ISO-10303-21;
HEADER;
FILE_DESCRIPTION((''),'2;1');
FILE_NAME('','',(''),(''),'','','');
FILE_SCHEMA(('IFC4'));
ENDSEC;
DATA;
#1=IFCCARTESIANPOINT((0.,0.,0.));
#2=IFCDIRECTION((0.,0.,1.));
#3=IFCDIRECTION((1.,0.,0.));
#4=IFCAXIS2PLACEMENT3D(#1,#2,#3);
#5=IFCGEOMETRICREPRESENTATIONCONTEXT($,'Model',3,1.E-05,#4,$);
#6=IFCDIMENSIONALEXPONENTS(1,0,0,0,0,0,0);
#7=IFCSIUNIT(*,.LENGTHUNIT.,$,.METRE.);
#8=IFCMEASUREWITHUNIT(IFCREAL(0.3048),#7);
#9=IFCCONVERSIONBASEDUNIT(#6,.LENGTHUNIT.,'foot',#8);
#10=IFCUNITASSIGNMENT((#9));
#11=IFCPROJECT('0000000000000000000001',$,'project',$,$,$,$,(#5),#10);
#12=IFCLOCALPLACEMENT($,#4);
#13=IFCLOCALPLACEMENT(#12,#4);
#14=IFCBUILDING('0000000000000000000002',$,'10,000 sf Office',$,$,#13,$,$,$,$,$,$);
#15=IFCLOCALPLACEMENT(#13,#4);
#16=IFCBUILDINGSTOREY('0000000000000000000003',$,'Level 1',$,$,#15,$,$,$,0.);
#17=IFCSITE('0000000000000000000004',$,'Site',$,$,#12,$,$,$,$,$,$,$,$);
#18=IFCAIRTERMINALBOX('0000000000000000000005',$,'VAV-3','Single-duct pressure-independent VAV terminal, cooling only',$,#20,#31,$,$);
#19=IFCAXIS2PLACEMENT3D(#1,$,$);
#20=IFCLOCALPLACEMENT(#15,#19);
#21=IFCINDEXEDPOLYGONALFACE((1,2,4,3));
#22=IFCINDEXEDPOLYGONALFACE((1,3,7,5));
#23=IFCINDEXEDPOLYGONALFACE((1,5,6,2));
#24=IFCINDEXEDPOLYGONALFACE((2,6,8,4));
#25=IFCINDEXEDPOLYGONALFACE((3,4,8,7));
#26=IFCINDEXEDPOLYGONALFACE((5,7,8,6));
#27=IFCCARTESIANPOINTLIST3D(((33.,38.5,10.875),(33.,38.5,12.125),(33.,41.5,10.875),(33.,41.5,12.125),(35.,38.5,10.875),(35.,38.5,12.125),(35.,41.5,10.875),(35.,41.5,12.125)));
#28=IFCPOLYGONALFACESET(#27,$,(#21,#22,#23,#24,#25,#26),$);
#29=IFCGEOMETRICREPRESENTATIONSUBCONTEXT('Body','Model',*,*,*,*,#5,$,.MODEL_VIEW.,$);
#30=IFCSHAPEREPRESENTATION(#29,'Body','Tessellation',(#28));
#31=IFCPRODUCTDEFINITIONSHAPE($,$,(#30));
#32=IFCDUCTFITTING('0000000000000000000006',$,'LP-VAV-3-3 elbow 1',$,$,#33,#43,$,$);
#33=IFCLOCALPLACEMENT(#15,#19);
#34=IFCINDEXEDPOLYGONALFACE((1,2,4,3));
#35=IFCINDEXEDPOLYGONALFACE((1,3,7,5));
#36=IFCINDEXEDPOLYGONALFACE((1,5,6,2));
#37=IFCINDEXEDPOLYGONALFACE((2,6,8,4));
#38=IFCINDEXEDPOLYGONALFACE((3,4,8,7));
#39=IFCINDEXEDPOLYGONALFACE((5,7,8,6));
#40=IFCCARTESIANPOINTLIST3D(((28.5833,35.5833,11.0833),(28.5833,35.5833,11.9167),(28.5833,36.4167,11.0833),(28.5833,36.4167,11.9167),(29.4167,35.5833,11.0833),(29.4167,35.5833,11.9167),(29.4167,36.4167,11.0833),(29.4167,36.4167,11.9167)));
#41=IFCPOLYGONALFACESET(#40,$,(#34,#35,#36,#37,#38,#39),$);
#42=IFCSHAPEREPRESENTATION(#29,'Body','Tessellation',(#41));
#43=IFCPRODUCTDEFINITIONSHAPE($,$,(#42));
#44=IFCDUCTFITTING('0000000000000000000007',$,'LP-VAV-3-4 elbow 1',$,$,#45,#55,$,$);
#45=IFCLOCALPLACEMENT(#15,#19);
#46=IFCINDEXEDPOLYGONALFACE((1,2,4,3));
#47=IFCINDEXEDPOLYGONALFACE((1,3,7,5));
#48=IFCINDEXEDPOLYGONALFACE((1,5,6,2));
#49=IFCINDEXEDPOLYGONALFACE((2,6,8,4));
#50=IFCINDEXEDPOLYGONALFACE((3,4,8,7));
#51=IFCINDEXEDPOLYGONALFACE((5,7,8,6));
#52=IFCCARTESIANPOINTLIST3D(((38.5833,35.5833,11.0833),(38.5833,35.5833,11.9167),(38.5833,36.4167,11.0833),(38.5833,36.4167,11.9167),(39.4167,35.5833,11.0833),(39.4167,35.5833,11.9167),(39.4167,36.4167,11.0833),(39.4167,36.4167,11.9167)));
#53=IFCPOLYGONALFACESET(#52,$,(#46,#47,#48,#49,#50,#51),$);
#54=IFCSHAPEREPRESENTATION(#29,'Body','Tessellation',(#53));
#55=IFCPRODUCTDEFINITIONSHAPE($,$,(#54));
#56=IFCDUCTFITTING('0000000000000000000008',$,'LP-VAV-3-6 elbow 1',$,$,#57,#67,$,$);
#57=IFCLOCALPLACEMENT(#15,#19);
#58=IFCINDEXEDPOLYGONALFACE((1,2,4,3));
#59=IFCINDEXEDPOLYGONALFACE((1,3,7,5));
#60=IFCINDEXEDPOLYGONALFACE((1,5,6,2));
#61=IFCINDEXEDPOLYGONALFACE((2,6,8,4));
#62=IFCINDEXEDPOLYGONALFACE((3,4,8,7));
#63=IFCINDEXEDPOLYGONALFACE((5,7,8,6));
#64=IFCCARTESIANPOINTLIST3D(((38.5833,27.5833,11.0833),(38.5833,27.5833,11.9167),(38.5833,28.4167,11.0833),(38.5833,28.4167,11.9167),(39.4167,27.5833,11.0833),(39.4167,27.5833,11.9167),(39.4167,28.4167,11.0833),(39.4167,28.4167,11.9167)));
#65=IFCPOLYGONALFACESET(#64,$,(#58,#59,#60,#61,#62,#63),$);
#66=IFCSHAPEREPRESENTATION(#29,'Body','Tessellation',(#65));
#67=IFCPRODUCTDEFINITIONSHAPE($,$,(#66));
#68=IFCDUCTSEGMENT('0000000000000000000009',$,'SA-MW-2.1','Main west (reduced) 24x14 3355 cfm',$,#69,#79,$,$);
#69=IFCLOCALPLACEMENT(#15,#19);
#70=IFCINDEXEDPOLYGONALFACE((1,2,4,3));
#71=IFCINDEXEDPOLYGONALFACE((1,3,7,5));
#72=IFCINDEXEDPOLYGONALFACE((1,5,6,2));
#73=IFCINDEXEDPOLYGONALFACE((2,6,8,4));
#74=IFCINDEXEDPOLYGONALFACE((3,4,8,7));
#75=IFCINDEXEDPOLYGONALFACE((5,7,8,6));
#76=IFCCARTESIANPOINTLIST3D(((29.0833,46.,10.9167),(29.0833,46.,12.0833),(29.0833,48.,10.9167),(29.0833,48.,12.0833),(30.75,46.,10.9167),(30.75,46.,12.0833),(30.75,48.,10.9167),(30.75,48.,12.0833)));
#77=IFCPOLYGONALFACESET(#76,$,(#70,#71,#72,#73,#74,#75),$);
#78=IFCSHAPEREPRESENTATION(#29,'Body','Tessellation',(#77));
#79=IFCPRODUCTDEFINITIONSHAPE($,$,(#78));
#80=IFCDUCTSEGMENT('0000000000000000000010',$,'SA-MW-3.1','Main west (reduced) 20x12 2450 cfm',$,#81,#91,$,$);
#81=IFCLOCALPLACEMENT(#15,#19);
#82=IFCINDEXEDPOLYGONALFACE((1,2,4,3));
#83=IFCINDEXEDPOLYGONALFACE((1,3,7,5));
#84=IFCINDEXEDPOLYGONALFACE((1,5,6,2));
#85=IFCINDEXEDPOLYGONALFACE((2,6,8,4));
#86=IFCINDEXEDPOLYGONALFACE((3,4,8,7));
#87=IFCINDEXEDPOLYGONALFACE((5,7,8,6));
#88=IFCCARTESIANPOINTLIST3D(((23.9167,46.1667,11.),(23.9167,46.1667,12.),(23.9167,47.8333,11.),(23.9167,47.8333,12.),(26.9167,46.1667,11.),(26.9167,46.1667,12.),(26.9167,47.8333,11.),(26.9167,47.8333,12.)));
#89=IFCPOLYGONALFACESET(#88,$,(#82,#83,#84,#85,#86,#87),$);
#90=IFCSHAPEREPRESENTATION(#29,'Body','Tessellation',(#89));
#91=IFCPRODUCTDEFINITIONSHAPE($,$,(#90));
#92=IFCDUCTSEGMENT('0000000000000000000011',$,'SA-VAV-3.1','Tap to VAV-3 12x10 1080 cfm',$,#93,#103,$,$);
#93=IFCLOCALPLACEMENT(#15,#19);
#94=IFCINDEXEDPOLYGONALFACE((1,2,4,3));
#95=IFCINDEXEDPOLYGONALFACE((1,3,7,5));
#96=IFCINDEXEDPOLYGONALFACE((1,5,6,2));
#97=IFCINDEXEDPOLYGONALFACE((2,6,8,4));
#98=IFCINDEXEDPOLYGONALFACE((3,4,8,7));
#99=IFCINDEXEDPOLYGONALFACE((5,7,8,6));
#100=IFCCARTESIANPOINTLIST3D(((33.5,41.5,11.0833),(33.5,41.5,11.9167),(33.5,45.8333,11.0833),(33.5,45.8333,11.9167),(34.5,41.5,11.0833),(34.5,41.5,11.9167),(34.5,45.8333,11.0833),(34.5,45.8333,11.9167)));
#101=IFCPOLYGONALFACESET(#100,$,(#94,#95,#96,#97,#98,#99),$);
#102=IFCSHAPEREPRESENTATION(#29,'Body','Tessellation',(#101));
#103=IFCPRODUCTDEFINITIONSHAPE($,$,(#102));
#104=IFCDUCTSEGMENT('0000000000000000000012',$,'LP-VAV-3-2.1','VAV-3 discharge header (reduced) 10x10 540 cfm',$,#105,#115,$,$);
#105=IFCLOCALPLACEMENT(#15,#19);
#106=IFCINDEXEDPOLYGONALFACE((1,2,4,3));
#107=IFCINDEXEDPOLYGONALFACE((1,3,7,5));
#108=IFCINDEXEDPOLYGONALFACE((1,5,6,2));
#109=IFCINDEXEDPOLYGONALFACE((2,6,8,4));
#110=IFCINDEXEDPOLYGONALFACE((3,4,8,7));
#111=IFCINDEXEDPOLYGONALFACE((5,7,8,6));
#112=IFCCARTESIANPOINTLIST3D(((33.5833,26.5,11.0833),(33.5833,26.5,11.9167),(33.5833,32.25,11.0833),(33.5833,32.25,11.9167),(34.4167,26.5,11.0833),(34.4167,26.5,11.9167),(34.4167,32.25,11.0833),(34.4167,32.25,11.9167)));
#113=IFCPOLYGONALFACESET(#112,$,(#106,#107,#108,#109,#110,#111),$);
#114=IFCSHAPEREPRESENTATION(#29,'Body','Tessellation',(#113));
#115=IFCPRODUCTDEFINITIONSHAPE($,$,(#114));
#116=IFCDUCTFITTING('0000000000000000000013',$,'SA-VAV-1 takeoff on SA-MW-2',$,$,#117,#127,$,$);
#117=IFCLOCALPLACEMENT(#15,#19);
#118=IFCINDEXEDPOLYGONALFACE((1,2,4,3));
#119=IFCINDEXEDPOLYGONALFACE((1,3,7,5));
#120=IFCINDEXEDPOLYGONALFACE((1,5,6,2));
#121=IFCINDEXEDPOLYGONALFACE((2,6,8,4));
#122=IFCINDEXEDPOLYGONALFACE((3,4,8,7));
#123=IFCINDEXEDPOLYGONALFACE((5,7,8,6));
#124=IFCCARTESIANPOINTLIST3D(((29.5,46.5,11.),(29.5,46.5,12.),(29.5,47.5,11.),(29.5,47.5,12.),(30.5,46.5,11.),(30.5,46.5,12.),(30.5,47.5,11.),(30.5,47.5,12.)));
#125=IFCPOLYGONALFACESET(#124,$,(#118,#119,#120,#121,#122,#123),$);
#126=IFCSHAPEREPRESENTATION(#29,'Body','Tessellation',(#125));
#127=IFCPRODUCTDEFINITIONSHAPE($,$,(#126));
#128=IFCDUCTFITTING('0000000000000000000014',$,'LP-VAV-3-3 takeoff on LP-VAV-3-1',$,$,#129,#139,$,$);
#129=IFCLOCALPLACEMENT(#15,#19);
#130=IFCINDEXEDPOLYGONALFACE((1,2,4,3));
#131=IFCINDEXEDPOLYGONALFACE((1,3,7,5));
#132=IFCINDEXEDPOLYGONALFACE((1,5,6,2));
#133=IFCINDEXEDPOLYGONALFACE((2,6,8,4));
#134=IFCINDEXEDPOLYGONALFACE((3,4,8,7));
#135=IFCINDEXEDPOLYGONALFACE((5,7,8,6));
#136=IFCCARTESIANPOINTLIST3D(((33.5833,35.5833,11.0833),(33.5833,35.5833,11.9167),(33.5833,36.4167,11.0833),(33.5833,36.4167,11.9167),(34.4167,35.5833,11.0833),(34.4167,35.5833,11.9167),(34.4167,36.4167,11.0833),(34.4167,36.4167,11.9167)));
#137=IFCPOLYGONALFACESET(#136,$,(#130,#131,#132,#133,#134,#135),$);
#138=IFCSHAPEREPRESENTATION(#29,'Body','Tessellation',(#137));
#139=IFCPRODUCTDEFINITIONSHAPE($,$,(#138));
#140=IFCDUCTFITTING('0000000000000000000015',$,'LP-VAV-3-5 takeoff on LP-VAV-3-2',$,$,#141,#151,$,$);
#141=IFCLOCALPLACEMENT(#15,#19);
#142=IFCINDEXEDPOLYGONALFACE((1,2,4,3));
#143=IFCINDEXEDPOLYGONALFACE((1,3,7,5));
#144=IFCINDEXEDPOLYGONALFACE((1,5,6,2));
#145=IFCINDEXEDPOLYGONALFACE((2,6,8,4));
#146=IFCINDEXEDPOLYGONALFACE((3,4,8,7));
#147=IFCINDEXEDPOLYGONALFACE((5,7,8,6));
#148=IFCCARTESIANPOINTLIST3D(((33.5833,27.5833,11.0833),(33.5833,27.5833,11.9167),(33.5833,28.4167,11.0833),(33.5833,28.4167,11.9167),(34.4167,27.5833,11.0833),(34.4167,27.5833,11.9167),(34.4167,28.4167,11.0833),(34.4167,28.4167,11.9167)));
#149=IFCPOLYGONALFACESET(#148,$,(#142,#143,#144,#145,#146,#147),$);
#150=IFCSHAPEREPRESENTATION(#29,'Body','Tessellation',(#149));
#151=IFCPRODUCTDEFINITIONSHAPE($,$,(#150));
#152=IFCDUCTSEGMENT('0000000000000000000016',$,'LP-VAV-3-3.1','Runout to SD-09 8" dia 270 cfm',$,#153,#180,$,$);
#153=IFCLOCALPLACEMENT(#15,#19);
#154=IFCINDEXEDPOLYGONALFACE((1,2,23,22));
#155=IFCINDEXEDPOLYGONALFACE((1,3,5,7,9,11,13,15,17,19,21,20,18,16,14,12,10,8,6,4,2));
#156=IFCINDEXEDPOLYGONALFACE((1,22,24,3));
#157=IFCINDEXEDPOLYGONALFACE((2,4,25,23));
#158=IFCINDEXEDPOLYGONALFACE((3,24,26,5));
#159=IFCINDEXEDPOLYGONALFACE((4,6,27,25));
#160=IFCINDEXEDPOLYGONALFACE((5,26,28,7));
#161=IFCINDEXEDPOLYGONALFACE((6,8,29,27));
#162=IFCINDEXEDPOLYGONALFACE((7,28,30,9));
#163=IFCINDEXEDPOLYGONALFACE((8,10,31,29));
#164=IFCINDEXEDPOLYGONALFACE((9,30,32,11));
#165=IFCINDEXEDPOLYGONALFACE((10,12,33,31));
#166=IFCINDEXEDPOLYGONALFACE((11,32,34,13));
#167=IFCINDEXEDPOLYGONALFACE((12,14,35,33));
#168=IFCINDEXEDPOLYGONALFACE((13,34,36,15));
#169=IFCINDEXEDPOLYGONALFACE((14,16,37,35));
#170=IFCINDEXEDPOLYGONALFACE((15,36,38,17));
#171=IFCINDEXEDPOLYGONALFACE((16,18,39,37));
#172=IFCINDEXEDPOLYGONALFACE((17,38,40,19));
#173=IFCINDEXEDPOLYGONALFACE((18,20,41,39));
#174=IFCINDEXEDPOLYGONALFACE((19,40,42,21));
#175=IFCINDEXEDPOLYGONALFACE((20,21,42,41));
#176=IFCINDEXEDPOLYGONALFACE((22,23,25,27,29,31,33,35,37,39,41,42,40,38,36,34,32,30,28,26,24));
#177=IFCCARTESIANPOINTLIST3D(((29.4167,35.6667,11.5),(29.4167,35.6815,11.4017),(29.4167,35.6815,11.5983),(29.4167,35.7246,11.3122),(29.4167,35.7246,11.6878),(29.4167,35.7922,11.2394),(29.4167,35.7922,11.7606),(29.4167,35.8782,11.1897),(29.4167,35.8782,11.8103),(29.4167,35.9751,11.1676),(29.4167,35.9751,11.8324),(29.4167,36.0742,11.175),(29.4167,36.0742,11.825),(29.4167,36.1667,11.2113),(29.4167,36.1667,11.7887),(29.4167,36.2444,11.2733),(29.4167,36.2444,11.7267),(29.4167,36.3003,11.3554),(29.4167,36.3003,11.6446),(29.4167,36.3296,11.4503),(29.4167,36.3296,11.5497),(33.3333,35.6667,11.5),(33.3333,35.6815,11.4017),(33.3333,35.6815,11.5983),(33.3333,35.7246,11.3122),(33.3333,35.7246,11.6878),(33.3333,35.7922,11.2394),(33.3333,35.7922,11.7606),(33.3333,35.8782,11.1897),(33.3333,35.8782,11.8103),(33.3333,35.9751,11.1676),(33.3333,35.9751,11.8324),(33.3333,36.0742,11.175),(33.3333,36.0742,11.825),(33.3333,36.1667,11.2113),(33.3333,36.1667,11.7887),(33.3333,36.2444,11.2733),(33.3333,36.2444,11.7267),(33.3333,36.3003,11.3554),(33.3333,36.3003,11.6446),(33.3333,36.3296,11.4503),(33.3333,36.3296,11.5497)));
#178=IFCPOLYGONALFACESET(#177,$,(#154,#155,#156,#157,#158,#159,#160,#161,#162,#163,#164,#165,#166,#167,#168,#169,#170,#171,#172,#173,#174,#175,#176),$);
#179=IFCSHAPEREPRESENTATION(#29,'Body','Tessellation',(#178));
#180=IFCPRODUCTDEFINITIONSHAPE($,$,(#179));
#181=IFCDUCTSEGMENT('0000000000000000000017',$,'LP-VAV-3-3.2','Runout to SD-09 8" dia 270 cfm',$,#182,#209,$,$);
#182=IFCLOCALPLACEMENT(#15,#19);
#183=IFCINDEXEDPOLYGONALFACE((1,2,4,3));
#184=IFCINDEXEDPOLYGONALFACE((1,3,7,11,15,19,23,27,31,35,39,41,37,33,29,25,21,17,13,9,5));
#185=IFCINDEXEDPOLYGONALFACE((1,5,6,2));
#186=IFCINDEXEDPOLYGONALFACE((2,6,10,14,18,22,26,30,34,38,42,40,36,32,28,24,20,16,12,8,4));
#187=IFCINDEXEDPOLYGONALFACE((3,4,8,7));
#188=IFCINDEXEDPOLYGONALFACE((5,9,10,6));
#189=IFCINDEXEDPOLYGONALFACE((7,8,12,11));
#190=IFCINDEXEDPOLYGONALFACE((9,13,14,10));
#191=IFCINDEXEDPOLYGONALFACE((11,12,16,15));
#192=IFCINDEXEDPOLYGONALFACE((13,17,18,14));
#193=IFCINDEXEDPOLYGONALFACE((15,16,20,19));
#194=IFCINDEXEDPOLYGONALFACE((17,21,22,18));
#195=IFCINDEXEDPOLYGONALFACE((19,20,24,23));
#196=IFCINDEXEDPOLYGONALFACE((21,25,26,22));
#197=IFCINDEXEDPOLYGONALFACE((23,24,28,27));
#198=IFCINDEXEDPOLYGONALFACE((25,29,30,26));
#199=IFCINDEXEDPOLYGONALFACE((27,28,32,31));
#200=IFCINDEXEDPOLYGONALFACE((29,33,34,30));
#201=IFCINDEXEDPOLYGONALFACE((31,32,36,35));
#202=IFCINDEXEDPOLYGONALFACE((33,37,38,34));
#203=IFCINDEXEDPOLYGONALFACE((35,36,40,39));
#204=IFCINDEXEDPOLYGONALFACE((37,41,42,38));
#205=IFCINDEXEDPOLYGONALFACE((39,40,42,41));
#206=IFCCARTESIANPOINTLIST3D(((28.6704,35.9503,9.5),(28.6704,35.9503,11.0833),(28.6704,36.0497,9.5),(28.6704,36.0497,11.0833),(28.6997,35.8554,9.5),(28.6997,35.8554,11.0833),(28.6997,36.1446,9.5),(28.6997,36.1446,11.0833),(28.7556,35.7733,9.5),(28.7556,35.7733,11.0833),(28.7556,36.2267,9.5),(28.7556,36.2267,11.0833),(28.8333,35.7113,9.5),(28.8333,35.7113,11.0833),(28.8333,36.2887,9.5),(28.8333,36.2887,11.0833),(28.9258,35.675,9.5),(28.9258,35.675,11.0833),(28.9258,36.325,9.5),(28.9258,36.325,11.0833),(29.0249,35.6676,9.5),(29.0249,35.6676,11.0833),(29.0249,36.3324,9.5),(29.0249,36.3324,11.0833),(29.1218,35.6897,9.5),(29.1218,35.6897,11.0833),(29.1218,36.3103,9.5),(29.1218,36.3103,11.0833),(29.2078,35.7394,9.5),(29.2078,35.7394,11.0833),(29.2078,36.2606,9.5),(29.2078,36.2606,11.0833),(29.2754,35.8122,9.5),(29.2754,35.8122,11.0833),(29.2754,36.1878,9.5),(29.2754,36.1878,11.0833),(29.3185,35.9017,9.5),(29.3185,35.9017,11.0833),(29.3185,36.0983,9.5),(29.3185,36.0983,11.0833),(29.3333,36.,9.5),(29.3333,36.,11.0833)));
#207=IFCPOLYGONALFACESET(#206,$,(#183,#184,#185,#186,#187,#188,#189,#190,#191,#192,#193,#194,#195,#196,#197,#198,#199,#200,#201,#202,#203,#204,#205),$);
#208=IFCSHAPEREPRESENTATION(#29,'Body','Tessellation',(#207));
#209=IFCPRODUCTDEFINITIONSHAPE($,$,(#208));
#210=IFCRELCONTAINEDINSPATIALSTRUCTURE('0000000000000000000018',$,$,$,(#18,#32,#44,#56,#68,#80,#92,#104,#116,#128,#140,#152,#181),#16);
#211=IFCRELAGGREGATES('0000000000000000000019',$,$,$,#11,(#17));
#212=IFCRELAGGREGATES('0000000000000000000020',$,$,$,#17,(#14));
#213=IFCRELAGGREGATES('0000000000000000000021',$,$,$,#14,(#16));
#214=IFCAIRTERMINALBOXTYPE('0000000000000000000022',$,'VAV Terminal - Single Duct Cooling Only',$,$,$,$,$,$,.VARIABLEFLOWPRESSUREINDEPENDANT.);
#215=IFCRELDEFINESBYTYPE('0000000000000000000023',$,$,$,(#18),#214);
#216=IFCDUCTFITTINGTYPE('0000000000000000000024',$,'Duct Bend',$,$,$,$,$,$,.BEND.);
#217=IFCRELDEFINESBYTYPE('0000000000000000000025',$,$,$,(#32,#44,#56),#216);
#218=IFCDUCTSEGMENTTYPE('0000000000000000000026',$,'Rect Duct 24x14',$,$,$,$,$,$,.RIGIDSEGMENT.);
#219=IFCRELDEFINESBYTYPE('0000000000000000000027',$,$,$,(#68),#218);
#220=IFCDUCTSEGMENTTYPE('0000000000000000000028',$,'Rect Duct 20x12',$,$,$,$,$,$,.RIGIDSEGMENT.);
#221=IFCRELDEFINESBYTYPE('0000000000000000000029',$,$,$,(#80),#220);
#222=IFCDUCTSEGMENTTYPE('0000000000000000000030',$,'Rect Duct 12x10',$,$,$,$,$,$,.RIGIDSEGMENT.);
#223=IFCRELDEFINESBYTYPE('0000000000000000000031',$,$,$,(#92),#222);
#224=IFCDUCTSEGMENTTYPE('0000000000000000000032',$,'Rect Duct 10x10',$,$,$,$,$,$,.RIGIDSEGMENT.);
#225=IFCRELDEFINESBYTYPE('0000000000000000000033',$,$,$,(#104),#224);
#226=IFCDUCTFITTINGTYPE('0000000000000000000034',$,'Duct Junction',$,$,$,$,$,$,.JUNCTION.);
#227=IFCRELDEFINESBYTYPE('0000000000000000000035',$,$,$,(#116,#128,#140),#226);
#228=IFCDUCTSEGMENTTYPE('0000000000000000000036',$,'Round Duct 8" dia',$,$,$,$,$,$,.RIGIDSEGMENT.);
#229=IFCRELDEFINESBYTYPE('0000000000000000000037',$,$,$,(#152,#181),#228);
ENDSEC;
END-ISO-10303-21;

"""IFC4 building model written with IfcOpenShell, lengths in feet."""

from ifc_helpers import new_model, entity, si_unit, converted_unit, frame, origin_with_axes, place, context, subcontext, project, spatial, rectangle, circle, extrude, type_object, element, save


model = new_model("IFC4")

# Units and contexts
model_context = context("Model", 3, precision=1e-05, world=origin_with_axes())
body_context = subcontext(model_context, "Body", "Model", "MODEL_VIEW")
ifc_project = project(units=[converted_unit("LENGTHUNIT", "foot", entity("IfcReal", 0.3048), si_unit("LENGTHUNIT", "METRE"), dimensions=[1, 0, 0, 0, 0, 0, 0])], contexts=[model_context])

# Site, building, storey
site_placement = place(None, origin_with_axes())
site = spatial("IfcSite", under=ifc_project, at=site_placement, Name="Site")
building_placement = place(site_placement, origin_with_axes())
building = spatial("IfcBuilding", under=site, at=building_placement, Name="10,000 sf Office")
storey_placement = place(building_placement, origin_with_axes())
storey = spatial("IfcBuildingStorey", under=building, at=storey_placement, Name="Level 1", Elevation=0.0)

# Air terminal box
air_terminal_box_type = type_object("IfcAirTerminalBoxType", Name="VAV Terminal - Single Duct Cooling Only", PredefinedType="VARIABLEFLOWPRESSUREINDEPENDANT")
air_terminal_box_placement = place(storey_placement, frame((34.0, 40.0, 10.875), z_axis=(0.0, 0.0, 1.0), x_axis=(0.0, -1.0, 0.0)))
element("IfcAirTerminalBox", 1, at=air_terminal_box_placement, inside=storey, type_object=air_terminal_box_type, Name="VAV-3", Description="Single-duct pressure-independent VAV terminal, cooling only", context=body_context, shape_type="SweptSolid", body=[
    extrude(rectangle(XDim=3.0, YDim=2.0), None, (0.0, 0.0, 1.0), 1.25),
])

# Duct fittings
duct_fitting_type_1 = type_object("IfcDuctFittingType", Name="Duct Bend", PredefinedType="BEND")
for number, where, z_axis, x_axis, name in (
    (2, (29.0, 36.0, 11.0833), (0.0, 0.0, 1.0), (1.0, 0.0, 0.0), "LP-VAV-3-3 elbow 1"),
    (3, (39.0, 36.0, 11.0833), (0.0, 0.0, 1.0), (1.0, 0.0, 0.0), "LP-VAV-3-4 elbow 1"),
    (4, (39.0, 28.0, 11.0833), (0.0, 0.0, 1.0), (1.0, 0.0, 0.0), "LP-VAV-3-6 elbow 1"),
):
    element("IfcDuctFitting", number, at=place(storey_placement, frame(where, z_axis=z_axis, x_axis=x_axis)), inside=storey, type_object=duct_fitting_type_1, Name=name, context=body_context, shape_type="SweptSolid", body=[
        extrude(rectangle(XDim=0.8333, YDim=0.8333), None, (0.0, 0.0, 1.0), 0.8333),
    ])

# Duct segments
duct_segment_type_1 = type_object("IfcDuctSegmentType", Name="Rect Duct 24x14", PredefinedType="RIGIDSEGMENT")
duct_segment_1_placement = place(storey_placement, frame((30.75, 47.0, 11.5), z_axis=(-1.0, 0.0, 0.0), x_axis=(0.0, -1.0, 0.0)))
element("IfcDuctSegment", 5, at=duct_segment_1_placement, inside=storey, type_object=duct_segment_type_1, Name="SA-MW-2.1", Description="Main west (reduced) 24x14 3355 cfm", context=body_context, shape_type="SweptSolid", body=[
    extrude(rectangle(XDim=2.0, YDim=1.1667), None, (0.0, 0.0, 1.0), 1.6667),
])
duct_segment_type_2 = type_object("IfcDuctSegmentType", Name="Rect Duct 20x12", PredefinedType="RIGIDSEGMENT")
duct_segment_2_placement = place(storey_placement, frame((26.9167, 47.0, 11.5), z_axis=(-1.0, 0.0, 0.0), x_axis=(0.0, -1.0, 0.0)))
element("IfcDuctSegment", 6, at=duct_segment_2_placement, inside=storey, type_object=duct_segment_type_2, Name="SA-MW-3.1", Description="Main west (reduced) 20x12 2450 cfm", context=body_context, shape_type="SweptSolid", body=[
    extrude(rectangle(XDim=1.6667, YDim=1.0), None, (0.0, 0.0, 1.0), 3.0),
])
duct_segment_type_3 = type_object("IfcDuctSegmentType", Name="Rect Duct 12x10", PredefinedType="RIGIDSEGMENT")
duct_segment_3_placement = place(storey_placement, frame((34.0, 45.8333, 11.5), z_axis=(0.0, -1.0, 0.0), x_axis=(1.0, 0.0, 0.0)))
element("IfcDuctSegment", 7, at=duct_segment_3_placement, inside=storey, type_object=duct_segment_type_3, Name="SA-VAV-3.1", Description="Tap to VAV-3 12x10 1080 cfm", context=body_context, shape_type="SweptSolid", body=[
    extrude(rectangle(XDim=1.0, YDim=0.8333), None, (0.0, 0.0, 1.0), 4.3333),
])
duct_segment_type_4 = type_object("IfcDuctSegmentType", Name="Rect Duct 10x10", PredefinedType="RIGIDSEGMENT")
duct_segment_4_placement = place(storey_placement, frame((34.0, 32.25, 11.5), z_axis=(0.0, -1.0, 0.0), x_axis=(1.0, 0.0, 0.0)))
element("IfcDuctSegment", 8, at=duct_segment_4_placement, inside=storey, type_object=duct_segment_type_4, Name="LP-VAV-3-2.1", Description="VAV-3 discharge header (reduced) 10x10 540 cfm", context=body_context, shape_type="SweptSolid", body=[
    extrude(rectangle(XDim=0.8333, YDim=0.8333), None, (0.0, 0.0, 1.0), 5.75),
])

# Duct fittings
duct_fitting_type_2 = type_object("IfcDuctFittingType", Name="Duct Junction", PredefinedType="JUNCTION")
duct_fitting_1_placement = place(storey_placement, frame((30.0, 47.0, 11.0), z_axis=(0.0, 0.0, 1.0), x_axis=(1.0, 0.0, 0.0)))
element("IfcDuctFitting", 9, at=duct_fitting_1_placement, inside=storey, type_object=duct_fitting_type_2, Name="SA-VAV-1 takeoff on SA-MW-2", context=body_context, shape_type="SweptSolid", body=[
    extrude(rectangle(XDim=1.0, YDim=1.0), None, (0.0, 0.0, 1.0), 1.0),
])
for number, where, z_axis, x_axis, name in (
    (10, (34.0, 36.0, 11.0833), (0.0, 0.0, 1.0), (1.0, 0.0, 0.0), "LP-VAV-3-3 takeoff on LP-VAV-3-1"),
    (11, (34.0, 28.0, 11.0833), (0.0, 0.0, 1.0), (1.0, 0.0, 0.0), "LP-VAV-3-5 takeoff on LP-VAV-3-2"),
):
    element("IfcDuctFitting", number, at=place(storey_placement, frame(where, z_axis=z_axis, x_axis=x_axis)), inside=storey, type_object=duct_fitting_type_2, Name=name, context=body_context, shape_type="SweptSolid", body=[
        extrude(rectangle(XDim=0.8333, YDim=0.8333), None, (0.0, 0.0, 1.0), 0.8333),
    ])

# Duct segments
duct_segment_type_5 = type_object("IfcDuctSegmentType", Name="Round Duct 8\" dia", PredefinedType="RIGIDSEGMENT")
duct_segment_5_placement = place(storey_placement, frame((33.3333, 36.0, 11.5), z_axis=(-1.0, 0.0, 0.0), x_axis=(0.0, -1.0, 0.0)))
element("IfcDuctSegment", 12, at=duct_segment_5_placement, inside=storey, type_object=duct_segment_type_5, Name="LP-VAV-3-3.1", Description="Runout to SD-09 8\" dia 270 cfm", context=body_context, shape_type="SweptSolid", body=[
    extrude(circle(Radius=0.3333), None, (0.0, 0.0, 1.0), 3.9167),
])
duct_segment_6_placement = place(storey_placement, frame((29.0, 36.0, 11.0833), z_axis=(0.0, 0.0, -1.0), x_axis=(1.0, 0.0, 0.0)))
element("IfcDuctSegment", 13, at=duct_segment_6_placement, inside=storey, type_object=duct_segment_type_5, Name="LP-VAV-3-3.2", Description="Runout to SD-09 8\" dia 270 cfm", context=body_context, shape_type="SweptSolid", body=[
    extrude(circle(Radius=0.3333), None, (0.0, 0.0, 1.0), 1.5833),
])

save(model, "model.ifc")
